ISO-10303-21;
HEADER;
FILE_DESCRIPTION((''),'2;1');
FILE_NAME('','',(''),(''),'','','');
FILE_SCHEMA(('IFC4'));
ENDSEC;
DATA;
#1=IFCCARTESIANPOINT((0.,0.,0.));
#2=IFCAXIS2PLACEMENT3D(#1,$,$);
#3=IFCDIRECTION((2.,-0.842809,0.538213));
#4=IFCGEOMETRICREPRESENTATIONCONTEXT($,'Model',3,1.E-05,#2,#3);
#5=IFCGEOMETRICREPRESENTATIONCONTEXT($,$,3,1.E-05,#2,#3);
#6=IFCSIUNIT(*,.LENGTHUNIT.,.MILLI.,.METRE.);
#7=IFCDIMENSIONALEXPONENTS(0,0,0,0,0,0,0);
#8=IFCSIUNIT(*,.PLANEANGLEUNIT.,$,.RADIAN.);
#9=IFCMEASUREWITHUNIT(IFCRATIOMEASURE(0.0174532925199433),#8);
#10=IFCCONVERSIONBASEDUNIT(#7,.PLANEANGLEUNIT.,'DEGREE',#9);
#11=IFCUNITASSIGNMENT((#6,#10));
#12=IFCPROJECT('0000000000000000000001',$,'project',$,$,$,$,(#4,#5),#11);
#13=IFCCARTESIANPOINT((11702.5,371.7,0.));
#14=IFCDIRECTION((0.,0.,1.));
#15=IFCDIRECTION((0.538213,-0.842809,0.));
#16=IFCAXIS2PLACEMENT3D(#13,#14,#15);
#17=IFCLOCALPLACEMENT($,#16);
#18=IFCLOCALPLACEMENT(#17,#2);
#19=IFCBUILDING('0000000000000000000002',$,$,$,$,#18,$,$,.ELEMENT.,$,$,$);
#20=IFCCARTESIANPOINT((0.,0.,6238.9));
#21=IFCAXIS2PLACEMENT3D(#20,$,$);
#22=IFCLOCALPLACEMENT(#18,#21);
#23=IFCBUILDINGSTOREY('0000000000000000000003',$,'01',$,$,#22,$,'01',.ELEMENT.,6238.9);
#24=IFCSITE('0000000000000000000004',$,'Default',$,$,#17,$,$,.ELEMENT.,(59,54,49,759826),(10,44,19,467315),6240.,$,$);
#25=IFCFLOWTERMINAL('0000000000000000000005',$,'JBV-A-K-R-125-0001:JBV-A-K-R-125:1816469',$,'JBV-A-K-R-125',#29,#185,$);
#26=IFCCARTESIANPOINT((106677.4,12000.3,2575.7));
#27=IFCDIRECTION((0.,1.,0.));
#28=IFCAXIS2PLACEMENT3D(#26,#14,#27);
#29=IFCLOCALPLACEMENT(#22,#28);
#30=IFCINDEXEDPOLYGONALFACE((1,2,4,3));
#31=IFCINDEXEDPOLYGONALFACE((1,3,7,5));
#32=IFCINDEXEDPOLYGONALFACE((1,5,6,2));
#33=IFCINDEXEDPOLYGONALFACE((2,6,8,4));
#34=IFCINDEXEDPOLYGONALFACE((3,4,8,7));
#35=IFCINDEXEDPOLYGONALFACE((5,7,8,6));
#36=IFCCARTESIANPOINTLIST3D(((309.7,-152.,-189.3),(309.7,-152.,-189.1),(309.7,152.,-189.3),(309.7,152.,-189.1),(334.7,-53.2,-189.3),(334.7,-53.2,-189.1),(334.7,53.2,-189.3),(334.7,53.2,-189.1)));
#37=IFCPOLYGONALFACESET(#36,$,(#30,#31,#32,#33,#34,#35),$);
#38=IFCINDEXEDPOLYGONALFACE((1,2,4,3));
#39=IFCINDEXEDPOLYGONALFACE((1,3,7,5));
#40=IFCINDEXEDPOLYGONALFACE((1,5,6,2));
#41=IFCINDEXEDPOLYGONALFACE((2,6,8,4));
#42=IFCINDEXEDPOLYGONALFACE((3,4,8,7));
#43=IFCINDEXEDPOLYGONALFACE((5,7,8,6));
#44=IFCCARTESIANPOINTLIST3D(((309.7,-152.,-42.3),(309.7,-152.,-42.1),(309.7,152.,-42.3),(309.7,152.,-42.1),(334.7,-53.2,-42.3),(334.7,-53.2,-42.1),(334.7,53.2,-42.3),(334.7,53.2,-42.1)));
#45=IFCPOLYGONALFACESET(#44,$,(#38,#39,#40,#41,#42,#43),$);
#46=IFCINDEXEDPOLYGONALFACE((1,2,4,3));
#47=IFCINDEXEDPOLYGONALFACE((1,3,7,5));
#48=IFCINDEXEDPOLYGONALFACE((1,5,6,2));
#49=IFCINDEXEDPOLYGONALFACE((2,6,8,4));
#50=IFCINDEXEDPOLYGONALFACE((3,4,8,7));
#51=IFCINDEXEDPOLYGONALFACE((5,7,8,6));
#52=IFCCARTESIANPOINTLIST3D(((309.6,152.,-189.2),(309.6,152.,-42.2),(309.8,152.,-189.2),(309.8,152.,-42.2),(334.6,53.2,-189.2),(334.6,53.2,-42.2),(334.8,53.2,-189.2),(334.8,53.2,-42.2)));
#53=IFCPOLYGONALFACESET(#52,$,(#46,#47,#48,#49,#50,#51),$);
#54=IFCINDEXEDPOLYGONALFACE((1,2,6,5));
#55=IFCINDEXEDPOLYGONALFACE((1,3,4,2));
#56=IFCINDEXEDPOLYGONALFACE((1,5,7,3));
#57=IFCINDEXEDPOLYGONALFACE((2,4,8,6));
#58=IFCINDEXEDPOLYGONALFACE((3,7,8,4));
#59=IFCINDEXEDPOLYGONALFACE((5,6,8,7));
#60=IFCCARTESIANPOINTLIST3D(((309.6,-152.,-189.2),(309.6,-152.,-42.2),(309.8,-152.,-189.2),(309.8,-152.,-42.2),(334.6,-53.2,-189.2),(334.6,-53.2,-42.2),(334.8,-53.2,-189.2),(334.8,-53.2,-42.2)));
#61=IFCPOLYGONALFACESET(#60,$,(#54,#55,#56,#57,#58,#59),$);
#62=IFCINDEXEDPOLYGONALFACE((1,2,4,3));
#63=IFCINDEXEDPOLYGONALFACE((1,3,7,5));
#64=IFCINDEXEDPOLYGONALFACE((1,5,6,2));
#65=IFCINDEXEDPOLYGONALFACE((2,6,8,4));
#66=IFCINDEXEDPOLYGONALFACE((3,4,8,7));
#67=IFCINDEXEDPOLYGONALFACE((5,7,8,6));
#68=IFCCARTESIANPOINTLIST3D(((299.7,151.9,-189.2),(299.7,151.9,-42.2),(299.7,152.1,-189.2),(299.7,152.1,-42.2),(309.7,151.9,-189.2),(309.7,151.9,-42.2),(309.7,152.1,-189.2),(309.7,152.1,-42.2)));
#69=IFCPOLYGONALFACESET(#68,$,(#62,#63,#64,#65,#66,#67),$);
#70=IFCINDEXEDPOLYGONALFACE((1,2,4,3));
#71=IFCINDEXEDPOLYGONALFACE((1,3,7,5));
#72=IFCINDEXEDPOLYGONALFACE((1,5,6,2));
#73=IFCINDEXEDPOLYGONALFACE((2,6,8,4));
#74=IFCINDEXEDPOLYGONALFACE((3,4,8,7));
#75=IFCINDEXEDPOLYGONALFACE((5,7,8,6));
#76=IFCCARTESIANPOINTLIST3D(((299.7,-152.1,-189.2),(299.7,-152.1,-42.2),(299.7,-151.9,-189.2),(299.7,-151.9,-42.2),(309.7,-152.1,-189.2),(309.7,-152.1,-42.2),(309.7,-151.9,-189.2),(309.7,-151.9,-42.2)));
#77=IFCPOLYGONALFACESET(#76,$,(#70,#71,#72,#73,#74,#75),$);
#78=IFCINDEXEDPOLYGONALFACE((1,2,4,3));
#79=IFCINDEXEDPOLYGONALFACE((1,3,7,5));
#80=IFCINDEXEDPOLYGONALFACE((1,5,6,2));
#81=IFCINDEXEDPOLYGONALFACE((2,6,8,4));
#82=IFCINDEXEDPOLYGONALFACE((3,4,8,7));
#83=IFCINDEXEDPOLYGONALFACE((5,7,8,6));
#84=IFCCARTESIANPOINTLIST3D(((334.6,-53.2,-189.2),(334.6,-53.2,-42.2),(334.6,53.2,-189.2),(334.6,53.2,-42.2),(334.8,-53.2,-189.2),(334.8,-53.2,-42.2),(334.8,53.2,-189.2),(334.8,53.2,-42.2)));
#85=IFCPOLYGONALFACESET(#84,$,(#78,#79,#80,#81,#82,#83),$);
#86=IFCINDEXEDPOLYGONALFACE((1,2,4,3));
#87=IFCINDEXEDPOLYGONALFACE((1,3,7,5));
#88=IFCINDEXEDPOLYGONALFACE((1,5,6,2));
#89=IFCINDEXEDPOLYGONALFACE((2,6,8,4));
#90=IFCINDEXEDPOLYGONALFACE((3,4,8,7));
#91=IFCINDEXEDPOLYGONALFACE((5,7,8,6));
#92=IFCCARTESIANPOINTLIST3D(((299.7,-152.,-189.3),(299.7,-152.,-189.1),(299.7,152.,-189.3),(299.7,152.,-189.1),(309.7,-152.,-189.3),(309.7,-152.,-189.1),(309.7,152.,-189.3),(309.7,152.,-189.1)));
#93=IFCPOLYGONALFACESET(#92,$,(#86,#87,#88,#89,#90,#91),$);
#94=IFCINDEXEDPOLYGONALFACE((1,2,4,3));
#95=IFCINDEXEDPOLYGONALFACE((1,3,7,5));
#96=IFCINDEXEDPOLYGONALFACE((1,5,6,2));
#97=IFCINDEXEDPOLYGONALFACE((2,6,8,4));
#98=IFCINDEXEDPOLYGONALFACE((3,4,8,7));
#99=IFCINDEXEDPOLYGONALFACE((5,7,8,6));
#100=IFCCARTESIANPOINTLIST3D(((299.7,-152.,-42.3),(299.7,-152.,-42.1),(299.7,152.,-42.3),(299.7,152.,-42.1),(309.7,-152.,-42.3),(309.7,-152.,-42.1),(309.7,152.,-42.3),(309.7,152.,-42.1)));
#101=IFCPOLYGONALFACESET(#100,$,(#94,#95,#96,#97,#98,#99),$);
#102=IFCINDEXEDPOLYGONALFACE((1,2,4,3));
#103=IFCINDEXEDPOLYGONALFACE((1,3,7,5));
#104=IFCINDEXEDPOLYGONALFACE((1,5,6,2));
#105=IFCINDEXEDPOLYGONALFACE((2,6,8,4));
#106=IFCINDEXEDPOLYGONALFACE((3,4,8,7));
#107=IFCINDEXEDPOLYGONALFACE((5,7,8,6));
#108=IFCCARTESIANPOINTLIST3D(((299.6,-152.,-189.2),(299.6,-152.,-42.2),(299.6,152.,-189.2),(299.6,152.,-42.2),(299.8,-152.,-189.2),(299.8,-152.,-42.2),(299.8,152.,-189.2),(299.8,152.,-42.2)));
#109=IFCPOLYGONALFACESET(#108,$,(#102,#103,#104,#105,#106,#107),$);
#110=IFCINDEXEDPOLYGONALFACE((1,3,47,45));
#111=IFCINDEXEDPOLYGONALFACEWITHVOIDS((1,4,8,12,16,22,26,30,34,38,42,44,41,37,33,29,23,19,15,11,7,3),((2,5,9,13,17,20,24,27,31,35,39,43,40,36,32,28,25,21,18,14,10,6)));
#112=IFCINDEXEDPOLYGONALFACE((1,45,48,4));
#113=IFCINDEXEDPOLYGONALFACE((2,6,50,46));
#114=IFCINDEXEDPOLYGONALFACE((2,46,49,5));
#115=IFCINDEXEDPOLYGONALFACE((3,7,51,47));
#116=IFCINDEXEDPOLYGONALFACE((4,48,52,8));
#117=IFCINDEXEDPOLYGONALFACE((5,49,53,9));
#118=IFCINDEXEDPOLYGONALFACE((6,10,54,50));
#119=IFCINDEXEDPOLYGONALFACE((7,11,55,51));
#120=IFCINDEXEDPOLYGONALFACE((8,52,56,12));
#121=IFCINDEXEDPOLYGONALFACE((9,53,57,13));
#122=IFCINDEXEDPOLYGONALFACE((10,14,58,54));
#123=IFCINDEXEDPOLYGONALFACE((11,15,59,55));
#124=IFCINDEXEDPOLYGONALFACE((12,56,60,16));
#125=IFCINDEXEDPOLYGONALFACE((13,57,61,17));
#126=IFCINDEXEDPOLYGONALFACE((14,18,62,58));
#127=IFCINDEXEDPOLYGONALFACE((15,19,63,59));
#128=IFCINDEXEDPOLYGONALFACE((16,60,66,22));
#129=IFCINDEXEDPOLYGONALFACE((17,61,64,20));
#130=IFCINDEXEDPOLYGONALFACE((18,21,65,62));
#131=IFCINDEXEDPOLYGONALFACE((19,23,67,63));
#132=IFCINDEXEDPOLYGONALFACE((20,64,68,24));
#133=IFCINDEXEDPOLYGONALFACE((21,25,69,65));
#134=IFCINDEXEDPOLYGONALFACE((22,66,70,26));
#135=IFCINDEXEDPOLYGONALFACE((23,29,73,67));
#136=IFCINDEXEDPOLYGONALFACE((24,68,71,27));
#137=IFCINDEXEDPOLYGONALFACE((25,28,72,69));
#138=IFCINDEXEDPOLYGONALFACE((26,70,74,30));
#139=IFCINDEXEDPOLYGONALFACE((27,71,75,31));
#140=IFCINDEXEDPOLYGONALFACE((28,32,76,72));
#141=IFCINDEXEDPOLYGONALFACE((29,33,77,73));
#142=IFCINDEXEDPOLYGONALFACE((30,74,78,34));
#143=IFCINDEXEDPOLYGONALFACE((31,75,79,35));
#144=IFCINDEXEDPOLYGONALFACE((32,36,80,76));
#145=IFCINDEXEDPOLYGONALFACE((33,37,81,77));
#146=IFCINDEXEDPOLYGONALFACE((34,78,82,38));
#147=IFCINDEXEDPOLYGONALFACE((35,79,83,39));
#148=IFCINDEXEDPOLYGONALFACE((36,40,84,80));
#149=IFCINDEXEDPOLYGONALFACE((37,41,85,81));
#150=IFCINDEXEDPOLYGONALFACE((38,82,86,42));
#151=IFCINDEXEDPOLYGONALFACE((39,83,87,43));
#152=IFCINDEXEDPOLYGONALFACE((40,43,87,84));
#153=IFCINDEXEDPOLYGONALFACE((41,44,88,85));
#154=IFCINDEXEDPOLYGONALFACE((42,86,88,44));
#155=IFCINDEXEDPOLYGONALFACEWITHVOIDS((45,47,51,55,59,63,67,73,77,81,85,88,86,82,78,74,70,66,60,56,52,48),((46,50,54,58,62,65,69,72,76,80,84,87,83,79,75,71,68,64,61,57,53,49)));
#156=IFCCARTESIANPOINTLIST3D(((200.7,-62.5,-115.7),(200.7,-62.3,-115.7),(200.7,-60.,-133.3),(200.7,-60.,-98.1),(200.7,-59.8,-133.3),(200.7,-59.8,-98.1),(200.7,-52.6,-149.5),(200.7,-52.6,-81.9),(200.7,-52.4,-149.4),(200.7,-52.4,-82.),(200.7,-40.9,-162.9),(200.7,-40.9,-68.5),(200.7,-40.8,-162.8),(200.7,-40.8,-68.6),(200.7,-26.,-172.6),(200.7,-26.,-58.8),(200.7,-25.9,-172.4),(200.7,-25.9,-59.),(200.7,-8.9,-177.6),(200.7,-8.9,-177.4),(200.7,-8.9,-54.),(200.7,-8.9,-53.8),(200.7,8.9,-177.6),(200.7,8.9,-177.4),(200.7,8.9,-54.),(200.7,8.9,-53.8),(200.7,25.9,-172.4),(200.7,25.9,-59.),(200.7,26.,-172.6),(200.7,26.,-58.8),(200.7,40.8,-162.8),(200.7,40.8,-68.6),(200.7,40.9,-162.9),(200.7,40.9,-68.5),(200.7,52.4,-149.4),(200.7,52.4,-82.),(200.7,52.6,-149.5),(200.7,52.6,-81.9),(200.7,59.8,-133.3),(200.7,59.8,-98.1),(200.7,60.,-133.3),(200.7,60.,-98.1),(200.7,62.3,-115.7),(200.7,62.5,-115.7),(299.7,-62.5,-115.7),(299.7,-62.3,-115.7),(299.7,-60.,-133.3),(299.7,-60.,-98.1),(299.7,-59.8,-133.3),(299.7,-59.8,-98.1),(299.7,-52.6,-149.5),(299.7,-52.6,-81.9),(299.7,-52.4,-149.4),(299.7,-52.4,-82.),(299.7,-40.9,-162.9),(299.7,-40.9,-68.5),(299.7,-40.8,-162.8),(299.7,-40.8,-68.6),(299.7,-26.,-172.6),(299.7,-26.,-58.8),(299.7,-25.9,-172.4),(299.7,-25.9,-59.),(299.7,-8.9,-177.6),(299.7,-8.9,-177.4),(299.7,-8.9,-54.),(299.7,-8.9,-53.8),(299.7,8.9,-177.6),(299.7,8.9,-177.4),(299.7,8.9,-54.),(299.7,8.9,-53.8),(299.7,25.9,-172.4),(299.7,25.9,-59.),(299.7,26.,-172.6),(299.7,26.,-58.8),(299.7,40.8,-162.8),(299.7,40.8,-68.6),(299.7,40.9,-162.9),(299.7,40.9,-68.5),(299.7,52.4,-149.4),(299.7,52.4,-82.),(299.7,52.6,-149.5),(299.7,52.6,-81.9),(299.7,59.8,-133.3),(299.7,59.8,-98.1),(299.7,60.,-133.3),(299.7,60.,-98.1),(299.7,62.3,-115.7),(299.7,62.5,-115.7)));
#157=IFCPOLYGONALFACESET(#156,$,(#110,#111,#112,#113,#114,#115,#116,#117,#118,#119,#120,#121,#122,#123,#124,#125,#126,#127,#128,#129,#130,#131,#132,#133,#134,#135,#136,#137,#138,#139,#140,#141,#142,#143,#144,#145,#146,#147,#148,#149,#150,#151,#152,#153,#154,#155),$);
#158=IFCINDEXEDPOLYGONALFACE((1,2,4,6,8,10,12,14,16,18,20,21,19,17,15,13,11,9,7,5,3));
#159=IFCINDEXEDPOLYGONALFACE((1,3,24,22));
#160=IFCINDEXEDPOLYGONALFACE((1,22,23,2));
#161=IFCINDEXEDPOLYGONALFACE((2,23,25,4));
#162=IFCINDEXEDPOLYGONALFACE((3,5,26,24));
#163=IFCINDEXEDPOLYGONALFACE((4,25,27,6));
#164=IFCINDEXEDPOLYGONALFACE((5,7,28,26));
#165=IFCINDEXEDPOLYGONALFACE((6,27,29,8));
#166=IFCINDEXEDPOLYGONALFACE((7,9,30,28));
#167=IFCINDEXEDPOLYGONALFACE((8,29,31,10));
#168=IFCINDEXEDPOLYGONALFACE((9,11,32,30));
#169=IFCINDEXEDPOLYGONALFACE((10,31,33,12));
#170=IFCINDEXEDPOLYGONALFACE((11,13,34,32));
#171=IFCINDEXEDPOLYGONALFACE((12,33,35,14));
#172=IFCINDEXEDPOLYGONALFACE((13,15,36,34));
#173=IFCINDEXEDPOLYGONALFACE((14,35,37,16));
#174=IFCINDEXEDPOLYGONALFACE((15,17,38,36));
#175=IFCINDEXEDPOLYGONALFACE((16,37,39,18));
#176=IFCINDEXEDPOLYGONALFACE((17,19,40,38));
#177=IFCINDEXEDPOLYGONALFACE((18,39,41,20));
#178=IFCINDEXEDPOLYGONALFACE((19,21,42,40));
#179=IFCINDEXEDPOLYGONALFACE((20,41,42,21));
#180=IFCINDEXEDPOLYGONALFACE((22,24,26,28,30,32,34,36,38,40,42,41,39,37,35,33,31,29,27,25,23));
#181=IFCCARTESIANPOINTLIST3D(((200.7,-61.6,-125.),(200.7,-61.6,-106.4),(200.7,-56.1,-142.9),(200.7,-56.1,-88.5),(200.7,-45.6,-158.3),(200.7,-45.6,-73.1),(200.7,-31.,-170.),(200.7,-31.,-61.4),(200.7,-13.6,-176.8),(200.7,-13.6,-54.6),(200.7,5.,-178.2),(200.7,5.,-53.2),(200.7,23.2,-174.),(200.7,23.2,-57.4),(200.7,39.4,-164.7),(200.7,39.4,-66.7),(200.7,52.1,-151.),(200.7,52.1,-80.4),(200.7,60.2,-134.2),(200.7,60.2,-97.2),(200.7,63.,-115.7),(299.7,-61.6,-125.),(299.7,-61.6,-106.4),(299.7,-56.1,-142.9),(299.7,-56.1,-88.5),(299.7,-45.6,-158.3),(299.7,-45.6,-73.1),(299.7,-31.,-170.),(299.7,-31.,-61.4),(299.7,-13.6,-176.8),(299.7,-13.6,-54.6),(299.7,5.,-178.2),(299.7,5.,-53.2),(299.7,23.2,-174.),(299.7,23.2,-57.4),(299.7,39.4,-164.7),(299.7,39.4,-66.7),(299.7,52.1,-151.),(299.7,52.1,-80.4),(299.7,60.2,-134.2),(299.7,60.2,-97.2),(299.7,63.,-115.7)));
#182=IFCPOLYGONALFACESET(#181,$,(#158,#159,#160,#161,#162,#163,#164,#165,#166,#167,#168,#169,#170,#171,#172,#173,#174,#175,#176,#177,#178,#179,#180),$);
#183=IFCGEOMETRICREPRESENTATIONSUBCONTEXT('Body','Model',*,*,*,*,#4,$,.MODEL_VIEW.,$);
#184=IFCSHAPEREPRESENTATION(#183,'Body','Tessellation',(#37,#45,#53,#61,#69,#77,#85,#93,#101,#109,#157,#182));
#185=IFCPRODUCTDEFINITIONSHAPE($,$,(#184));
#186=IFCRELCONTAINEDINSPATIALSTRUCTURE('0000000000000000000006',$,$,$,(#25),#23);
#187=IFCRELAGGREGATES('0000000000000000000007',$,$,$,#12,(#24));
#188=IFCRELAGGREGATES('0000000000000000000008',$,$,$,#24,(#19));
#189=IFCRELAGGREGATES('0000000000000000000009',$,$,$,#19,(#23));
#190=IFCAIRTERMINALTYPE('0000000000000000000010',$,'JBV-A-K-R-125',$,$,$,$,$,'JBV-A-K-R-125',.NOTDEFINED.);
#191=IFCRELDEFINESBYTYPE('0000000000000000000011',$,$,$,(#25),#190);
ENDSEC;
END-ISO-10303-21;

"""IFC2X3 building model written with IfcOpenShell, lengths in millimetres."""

from ifc_helpers import new_model, entity, si_unit, converted_unit, direction, frame, frame_2d, origin, origin_2d_with_axis, place, context, subcontext, project, spatial, polyline, circle_curve, parameter, trimmed, segment, composite_curve, rectangle, circle, outline, extrude, source, transform, mapped, type_object, type_shapes, element, save


model = new_model("IFC2X3")

# Units and contexts
model_context = context("Model", 3, precision=1e-05, world=origin(), true_north=direction((2.0, -0.842809, 0.538213)))
context_of_model = context(None, 3, precision=1e-05, world=origin(), true_north=direction((2.0, -0.842809, 0.538213)))
body_context = subcontext(model_context, "Body", "Model", "MODEL_VIEW")
ifc_project = project(units=[si_unit("LENGTHUNIT", "METRE", prefix="MILLI"), converted_unit("PLANEANGLEUNIT", "DEGREE", entity("IfcRatioMeasure", 0.0174532925199433), si_unit("PLANEANGLEUNIT", "RADIAN"), dimensions=[0, 0, 0, 0, 0, 0, 0])], contexts=[model_context, context_of_model])

# Site, building, storey
site_placement = place(None, frame((11702.5, 371.7, 0.0), z_axis=(0.0, 0.0, 1.0), x_axis=(0.538213, -0.842809, 0.0)))
site = spatial("IfcSite", under=ifc_project, at=site_placement, Name="Default", CompositionType="ELEMENT", RefLatitude=(59, 54, 49, 759826), RefLongitude=(10, 44, 19, 467315), RefElevation=6240.0)
building_placement = place(site_placement, origin())
building = spatial("IfcBuilding", under=site, at=building_placement, CompositionType="ELEMENT")
storey_placement = place(building_placement, frame((0.0, 0.0, 6238.9)))
storey = spatial("IfcBuildingStorey", under=building, at=storey_placement, Name="01", LongName="01", CompositionType="ELEMENT", Elevation=6238.9)

# Flow terminal
air_terminal_type_1 = type_object("IfcAirTerminalType", Name="JBV-A-K-R-125", ElementType="JBV-A-K-R-125", PredefinedType="NOTDEFINED")
shared_shape_1 = source(origin(), body_context, "Body", "SweptSolid", [
    extrude(outline(polyline([(-152.0, -12.5), (152.0, -12.5), (53.2, 12.5), (-53.2, 12.5), (-152.0, -12.5)])), frame((322.2, 0.0, -189.3), z_axis=(0.0, 0.0, 1.0), x_axis=(0.0, -1.0, 0.0)), (0.0, 0.0, 1.0), 0.2),
    extrude(outline(polyline([(-152.0, -12.5), (152.0, -12.5), (53.2, 12.5), (-53.2, 12.5), (-152.0, -12.5)])), frame((322.2, 0.0, -42.3), z_axis=(0.0, 0.0, 1.0), x_axis=(0.0, -1.0, 0.0)), (0.0, 0.0, 1.0), 0.2),
    extrude(rectangle(XDim=0.2, YDim=101.9, at=frame_2d((0.0, 0.0), x_axis=(1.0, 0.0))), frame((322.2, 102.6, -189.2), z_axis=(0.0, 0.0, 1.0), x_axis=(0.969446, 0.245305, 0.0)), (0.0, 0.0, 1.0), 147.0),
    extrude(rectangle(XDim=0.2, YDim=101.9, at=frame_2d((0.0, 0.0), x_axis=(1.0, 0.0))), frame((322.2, -102.6, -189.2), z_axis=(0.0, 0.0, 1.0), x_axis=(-0.969446, 0.245305, 0.0)), (0.0, 0.0, 1.0), 147.0),
    extrude(rectangle(XDim=0.2, YDim=10.0, at=frame_2d((0.0, 0.0), x_axis=(1.0, 0.0))), frame((304.7, 152.0, -189.2), z_axis=(0.0, 0.0, 1.0), x_axis=(0.0, 1.0, 0.0)), (0.0, 0.0, 1.0), 147.0),
    extrude(rectangle(XDim=0.2, YDim=10.0, at=frame_2d((0.0, 0.0), x_axis=(1.0, 0.0))), frame((304.7, -152.0, -189.2), z_axis=(0.0, 0.0, 1.0), x_axis=(0.0, 1.0, 0.0)), (0.0, 0.0, 1.0), 147.0),
    extrude(rectangle(XDim=0.2, YDim=106.4, at=frame_2d((0.0, 0.0), x_axis=(1.0, 0.0))), frame((334.7, 0.0, -189.2)), (0.0, 0.0, 1.0), 147.0),
    extrude(rectangle(XDim=304.0, YDim=10.0, at=frame_2d((0.0, 0.0), x_axis=(1.0, 0.0))), frame((304.7, 0.0, -189.3), z_axis=(0.0, 0.0, 1.0), x_axis=(0.0, -1.0, 0.0)), (0.0, 0.0, 1.0), 0.2),
    extrude(rectangle(XDim=304.0, YDim=10.0, at=frame_2d((0.0, 0.0), x_axis=(1.0, 0.0))), frame((304.7, 0.0, -42.3), z_axis=(0.0, 0.0, 1.0), x_axis=(0.0, -1.0, 0.0)), (0.0, 0.0, 1.0), 0.2),
    extrude(rectangle(XDim=0.2, YDim=304.0, at=frame_2d((0.0, 0.0), x_axis=(1.0, 0.0))), frame((299.7, 0.0, -189.2)), (0.0, 0.0, 1.0), 147.0),
    extrude(outline(composite_curve([segment(trimmed(circle_curve(origin_2d_with_axis(), 62.5), [parameter(0.0)], [parameter(180.0)], True, "PARAMETER"), True, "CONTINUOUS"), segment(trimmed(circle_curve(origin_2d_with_axis(), 62.5), [parameter(180.0)], [parameter(360.0)], True, "PARAMETER"), True, "CONTINUOUS")], self_intersect=False), holes=[composite_curve([segment(trimmed(circle_curve(origin_2d_with_axis(), 62.3), [parameter(180.0)], [parameter(360.0)], True, "PARAMETER"), False, "CONTINUOUS"), segment(trimmed(circle_curve(origin_2d_with_axis(), 62.3), [parameter(0.0)], [parameter(180.0)], True, "PARAMETER"), False, "CONTINUOUS")], self_intersect=False)]), frame((200.7, 0.0, -115.7), z_axis=(1.0, 0.0, 0.0), x_axis=(0.0, 1.0, 0.0)), (0.0, 0.0, 1.0), 99.0),
    extrude(circle(Radius=62.6, at=frame_2d((0.0, 0.0), x_axis=(1.0, 0.0))), frame((200.7, 0.3, -115.7), z_axis=(1.0, 0.0, 0.0), x_axis=(0.0, 1.0, 0.0)), (0.0, 0.0, 1.0), 99.0),
])
type_shapes(air_terminal_type_1, [shared_shape_1])
for number, where, z_axis, x_axis, name in (
    (1, (106677.4, 12000.3, 2575.7), (0.0, 0.0, 1.0), (0.0, 1.0, 0.0), "JBV-A-K-R-125-0001:JBV-A-K-R-125:1816469"),
):
    element("IfcFlowTerminal", number, at=place(storey_placement, frame(where, z_axis=z_axis, x_axis=x_axis)), inside=storey, type_object=air_terminal_type_1, Name=name, ObjectType="JBV-A-K-R-125", context=body_context, shape_type="MappedRepresentation", body=[
        mapped(shared_shape_1, transform((0.0, 0.0, 0.0), scale=1.0)),
    ])

save(model, "model.ifc")
